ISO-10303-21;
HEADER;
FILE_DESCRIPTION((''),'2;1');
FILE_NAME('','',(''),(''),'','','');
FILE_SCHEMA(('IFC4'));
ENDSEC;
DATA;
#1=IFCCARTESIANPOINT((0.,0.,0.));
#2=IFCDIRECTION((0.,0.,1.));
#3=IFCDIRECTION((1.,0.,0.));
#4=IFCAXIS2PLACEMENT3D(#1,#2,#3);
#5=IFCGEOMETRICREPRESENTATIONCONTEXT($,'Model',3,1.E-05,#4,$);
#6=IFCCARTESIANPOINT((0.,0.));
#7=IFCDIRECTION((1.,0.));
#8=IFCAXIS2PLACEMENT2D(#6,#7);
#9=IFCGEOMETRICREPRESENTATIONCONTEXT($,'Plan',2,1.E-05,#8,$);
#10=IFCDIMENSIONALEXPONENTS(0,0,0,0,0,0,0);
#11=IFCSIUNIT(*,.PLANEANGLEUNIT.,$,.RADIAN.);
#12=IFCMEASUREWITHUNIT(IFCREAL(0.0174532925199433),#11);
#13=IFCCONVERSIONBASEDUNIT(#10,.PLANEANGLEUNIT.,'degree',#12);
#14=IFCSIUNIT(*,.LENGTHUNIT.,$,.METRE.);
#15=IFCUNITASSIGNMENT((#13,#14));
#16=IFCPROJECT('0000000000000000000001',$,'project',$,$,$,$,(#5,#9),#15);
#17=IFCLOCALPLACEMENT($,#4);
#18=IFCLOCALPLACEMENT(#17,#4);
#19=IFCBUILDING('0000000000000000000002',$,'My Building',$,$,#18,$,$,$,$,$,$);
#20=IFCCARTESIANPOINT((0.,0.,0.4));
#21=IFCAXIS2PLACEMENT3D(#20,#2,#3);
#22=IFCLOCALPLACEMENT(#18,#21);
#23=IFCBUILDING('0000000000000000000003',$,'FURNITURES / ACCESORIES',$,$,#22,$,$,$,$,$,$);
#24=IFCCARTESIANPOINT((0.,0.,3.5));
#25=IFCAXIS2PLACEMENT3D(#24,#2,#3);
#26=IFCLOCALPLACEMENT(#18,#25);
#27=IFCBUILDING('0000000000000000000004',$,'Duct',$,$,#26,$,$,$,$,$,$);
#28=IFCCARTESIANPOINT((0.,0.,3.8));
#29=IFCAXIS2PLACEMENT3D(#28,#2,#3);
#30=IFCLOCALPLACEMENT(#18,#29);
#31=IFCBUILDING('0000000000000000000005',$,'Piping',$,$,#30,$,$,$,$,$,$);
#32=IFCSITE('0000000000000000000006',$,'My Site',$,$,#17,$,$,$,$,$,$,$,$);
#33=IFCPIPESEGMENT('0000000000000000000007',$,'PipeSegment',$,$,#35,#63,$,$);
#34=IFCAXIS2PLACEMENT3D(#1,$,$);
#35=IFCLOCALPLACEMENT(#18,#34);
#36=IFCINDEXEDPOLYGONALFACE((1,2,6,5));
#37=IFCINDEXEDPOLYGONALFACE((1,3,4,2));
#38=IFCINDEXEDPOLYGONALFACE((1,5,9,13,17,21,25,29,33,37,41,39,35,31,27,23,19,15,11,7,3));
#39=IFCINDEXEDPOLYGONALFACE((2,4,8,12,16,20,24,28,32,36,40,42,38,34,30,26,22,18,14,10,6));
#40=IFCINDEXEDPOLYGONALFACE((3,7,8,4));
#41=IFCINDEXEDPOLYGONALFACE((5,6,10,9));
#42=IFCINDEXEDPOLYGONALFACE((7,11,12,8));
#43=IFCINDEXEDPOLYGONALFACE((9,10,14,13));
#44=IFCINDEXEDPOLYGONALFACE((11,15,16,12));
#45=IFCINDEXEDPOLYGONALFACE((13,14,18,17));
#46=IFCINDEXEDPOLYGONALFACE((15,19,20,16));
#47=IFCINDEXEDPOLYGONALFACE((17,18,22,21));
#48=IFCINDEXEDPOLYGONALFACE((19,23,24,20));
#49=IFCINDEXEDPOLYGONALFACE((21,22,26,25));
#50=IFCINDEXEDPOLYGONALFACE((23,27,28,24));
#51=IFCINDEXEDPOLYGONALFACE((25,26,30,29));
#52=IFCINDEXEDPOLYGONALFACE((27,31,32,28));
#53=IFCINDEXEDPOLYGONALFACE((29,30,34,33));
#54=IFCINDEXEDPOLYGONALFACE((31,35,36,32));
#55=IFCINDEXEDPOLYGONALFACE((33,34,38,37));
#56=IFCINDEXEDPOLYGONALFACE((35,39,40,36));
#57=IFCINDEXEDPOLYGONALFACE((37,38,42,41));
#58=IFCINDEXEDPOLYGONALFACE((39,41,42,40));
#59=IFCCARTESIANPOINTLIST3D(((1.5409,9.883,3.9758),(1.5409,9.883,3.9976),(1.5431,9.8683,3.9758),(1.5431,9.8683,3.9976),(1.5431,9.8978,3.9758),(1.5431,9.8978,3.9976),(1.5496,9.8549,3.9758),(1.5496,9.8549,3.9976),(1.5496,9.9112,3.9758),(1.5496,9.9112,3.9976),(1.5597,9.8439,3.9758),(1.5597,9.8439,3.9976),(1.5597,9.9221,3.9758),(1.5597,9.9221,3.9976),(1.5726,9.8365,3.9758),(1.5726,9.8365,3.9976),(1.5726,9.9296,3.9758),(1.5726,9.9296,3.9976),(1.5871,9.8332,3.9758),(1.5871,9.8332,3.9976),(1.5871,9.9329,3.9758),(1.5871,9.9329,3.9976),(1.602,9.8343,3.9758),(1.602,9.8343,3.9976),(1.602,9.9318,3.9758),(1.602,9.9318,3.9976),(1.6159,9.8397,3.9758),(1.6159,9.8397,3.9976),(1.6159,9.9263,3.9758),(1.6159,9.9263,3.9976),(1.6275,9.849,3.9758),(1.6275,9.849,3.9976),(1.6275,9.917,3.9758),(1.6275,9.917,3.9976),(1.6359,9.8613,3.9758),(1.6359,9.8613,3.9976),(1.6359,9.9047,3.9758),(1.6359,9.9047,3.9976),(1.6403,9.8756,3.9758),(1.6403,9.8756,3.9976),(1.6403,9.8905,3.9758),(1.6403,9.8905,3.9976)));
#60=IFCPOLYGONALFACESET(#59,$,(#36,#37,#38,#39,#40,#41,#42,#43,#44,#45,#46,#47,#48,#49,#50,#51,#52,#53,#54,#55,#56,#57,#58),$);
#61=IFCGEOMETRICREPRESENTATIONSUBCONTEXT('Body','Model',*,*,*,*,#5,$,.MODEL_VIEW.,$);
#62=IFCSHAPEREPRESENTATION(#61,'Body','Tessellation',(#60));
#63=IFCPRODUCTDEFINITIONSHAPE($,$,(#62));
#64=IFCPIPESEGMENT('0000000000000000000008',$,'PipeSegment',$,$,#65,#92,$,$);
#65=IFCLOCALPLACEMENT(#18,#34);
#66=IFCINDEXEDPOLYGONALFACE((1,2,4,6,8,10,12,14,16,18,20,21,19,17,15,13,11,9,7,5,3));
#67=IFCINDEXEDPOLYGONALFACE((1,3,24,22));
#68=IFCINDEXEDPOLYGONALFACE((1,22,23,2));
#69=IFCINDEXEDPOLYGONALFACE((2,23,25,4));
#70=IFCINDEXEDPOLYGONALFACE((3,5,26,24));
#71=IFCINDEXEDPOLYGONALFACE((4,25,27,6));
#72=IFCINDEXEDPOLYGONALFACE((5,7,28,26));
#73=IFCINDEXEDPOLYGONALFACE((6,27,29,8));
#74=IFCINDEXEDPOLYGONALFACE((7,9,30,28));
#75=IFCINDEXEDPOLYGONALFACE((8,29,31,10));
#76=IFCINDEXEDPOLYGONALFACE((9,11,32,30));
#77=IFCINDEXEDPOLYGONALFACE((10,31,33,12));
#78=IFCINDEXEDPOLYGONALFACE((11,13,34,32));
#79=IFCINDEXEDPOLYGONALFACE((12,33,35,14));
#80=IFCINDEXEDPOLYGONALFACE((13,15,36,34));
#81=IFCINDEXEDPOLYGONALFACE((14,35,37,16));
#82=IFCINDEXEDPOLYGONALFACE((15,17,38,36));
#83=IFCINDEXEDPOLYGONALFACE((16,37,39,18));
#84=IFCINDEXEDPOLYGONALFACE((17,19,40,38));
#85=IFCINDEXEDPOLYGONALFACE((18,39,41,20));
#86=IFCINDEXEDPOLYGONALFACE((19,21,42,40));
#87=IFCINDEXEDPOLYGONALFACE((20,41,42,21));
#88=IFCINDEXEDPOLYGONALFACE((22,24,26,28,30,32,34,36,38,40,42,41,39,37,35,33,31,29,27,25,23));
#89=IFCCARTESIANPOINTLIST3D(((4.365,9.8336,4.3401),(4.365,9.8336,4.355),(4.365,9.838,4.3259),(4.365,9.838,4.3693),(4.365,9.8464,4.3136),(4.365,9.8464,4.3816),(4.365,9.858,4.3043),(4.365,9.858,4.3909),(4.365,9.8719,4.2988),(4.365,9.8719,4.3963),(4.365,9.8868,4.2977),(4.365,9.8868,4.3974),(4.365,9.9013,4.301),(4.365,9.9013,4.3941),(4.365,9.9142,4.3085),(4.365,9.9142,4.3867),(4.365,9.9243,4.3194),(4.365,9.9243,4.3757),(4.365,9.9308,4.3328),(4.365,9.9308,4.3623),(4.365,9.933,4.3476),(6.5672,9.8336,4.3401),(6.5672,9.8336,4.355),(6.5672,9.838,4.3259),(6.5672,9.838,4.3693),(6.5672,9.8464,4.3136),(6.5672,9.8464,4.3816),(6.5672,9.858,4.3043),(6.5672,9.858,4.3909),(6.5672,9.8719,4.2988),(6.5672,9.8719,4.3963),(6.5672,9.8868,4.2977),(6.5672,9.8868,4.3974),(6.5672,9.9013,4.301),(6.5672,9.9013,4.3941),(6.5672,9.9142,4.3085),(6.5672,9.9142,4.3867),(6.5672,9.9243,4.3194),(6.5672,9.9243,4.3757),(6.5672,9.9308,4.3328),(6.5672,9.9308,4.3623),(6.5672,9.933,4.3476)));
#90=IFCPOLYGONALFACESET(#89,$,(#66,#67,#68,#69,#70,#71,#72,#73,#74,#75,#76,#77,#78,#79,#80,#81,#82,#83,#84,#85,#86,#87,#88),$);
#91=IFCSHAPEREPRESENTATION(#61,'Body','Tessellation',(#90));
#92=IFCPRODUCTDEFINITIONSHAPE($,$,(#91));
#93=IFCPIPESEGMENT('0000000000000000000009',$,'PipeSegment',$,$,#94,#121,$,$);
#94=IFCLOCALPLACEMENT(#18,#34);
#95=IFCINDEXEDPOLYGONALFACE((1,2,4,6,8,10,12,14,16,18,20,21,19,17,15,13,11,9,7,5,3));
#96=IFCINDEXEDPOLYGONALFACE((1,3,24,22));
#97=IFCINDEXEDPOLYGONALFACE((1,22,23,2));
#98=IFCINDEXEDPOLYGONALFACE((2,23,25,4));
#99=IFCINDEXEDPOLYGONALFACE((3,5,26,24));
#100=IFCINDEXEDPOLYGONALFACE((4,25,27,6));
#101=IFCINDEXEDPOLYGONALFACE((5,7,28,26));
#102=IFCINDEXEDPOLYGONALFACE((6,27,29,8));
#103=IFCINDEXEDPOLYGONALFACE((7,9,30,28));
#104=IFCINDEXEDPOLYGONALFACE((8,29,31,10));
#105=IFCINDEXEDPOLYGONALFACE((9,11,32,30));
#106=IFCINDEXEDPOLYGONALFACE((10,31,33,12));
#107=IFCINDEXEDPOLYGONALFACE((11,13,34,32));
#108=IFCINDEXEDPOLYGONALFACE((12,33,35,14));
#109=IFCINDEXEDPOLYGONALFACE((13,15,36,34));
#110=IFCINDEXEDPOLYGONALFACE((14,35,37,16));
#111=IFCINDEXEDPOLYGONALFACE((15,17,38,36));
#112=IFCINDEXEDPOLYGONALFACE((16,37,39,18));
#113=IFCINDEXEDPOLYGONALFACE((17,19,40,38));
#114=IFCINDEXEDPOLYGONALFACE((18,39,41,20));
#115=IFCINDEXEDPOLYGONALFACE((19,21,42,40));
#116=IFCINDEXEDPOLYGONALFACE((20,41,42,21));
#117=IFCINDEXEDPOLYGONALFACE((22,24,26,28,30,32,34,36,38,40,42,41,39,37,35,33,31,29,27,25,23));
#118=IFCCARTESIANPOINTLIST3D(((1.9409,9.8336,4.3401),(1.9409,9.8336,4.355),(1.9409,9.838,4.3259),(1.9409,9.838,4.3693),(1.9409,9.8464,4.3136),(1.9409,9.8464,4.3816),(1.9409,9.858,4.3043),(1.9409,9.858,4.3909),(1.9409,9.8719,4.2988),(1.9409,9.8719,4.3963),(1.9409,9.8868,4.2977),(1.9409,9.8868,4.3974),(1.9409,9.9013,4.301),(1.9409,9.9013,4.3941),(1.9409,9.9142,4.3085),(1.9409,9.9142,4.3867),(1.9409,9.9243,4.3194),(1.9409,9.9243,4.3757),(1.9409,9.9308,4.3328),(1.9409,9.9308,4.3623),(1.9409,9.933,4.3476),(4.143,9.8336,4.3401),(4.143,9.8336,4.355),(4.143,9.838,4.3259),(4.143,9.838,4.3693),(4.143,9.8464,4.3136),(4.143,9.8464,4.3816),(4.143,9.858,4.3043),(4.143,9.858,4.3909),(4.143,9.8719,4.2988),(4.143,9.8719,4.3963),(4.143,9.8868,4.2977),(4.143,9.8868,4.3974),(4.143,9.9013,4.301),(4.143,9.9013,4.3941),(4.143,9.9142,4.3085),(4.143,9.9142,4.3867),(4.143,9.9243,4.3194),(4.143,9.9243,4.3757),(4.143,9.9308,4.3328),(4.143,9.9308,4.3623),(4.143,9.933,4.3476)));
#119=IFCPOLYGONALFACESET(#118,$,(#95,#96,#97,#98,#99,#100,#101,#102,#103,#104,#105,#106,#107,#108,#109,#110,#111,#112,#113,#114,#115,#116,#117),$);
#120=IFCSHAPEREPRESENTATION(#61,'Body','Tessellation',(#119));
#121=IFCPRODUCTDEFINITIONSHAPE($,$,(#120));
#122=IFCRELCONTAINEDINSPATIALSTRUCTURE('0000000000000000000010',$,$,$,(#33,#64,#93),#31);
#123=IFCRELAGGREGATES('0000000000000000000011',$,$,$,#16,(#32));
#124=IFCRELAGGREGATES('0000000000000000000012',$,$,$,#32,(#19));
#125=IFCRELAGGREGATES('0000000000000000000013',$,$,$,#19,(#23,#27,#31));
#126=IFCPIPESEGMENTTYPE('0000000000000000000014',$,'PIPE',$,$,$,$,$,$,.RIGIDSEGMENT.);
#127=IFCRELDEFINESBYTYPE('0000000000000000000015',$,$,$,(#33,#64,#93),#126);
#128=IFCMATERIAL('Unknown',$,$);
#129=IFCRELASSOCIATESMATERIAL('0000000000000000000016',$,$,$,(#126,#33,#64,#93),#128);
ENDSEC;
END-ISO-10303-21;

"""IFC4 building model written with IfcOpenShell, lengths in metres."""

from ifc_helpers import new_model, entity, si_unit, converted_unit, frame, origin_with_axes, origin_2d_with_axis, place, context, subcontext, project, spatial, circle, extrude, material, material_profile, profile_set, profile_usage, type_object, element, save


model = new_model("IFC4")

# Units and contexts
model_context = context("Model", 3, precision=1e-05, world=origin_with_axes())
plan_context = context("Plan", 2, precision=1e-05, world=origin_2d_with_axis())
body_context = subcontext(model_context, "Body", "Model", "MODEL_VIEW")
ifc_project = project(units=[converted_unit("PLANEANGLEUNIT", "degree", entity("IfcReal", 0.0174532925199433), si_unit("PLANEANGLEUNIT", "RADIAN"), dimensions=[0, 0, 0, 0, 0, 0, 0]), si_unit("LENGTHUNIT", "METRE")], contexts=[model_context, plan_context])

# Site, building
site_placement = place(None, origin_with_axes())
site = spatial("IfcSite", under=ifc_project, at=site_placement, Name="My Site")
building_1_placement = place(site_placement, origin_with_axes())
building_1 = spatial("IfcBuilding", under=site, at=building_1_placement, Name="My Building")

# Shared definitions
ifc_material = material(Name="Unknown")

# Shared definitions
building_2_placement = place(building_1_placement, frame((0.0, 0.0, 0.4), z_axis=(0.0, 0.0, 1.0), x_axis=(1.0, 0.0, 0.0)))
building_2 = spatial("IfcBuilding", under=building_1, at=building_2_placement, Name="FURNITURES / ACCESORIES")

# Shared definitions
building_3_placement = place(building_1_placement, frame((0.0, 0.0, 3.5), z_axis=(0.0, 0.0, 1.0), x_axis=(1.0, 0.0, 0.0)))
building_3 = spatial("IfcBuilding", under=building_1, at=building_3_placement, Name="Duct")

# Shared definitions
building_4_placement = place(building_1_placement, frame((0.0, 0.0, 3.8), z_axis=(0.0, 0.0, 1.0), x_axis=(1.0, 0.0, 0.0)))
building_4 = spatial("IfcBuilding", under=building_1, at=building_4_placement, Name="Piping")

# Pipe segments
ifc_material_profile_1 = material_profile(ifc_material, circle(Radius=0.05))
ifc_profile_set_1 = profile_set([ifc_material_profile_1])
pipe_segment_type = type_object("IfcPipeSegmentType", Name="PIPE", PredefinedType="RIGIDSEGMENT", material=ifc_profile_set_1)
ifc_profile_usage_1 = profile_usage(ifc_profile_set_1, cardinal=5)
pipe_segment_1_placement = place(building_4_placement, frame((1.5909, 9.883, 0.1976), z_axis=(0.0, 0.0, -1.0), x_axis=(-1.0, 0.0, 0.0)))
element("IfcPipeSegment", 1, at=pipe_segment_1_placement, inside=building_4, type_object=pipe_segment_type, material=ifc_profile_usage_1, Name="PipeSegment", context=body_context, shape_type="SweptSolid", body=[
    extrude(circle(Radius=0.05), origin_with_axes(), (0.0, 0.0, 1.0), 0.0218),
])
ifc_profile_usage_2 = profile_usage(ifc_profile_set_1, cardinal=5)
pipe_segment_2_placement = place(building_4_placement, frame((4.365, 9.883, 0.5476), z_axis=(1.0, -0.000001, 0.000001), x_axis=(0.000001, 1.0, 0.0)))
element("IfcPipeSegment", 2, at=pipe_segment_2_placement, inside=building_4, type_object=pipe_segment_type, material=ifc_profile_usage_2, Name="PipeSegment", context=body_context, shape_type="SweptSolid", body=[
    extrude(circle(Radius=0.05), origin_with_axes(), (0.0, 0.0, 1.0), 2.2022),
])
ifc_profile_usage_3 = profile_usage(ifc_profile_set_1, cardinal=5)
pipe_segment_3_placement = place(building_4_placement, frame((4.143, 9.883, 0.5476), z_axis=(-1.0, -0.000001, -0.000001), x_axis=(-0.000001, 1.0, 0.0)))
element("IfcPipeSegment", 3, at=pipe_segment_3_placement, inside=building_4, type_object=pipe_segment_type, material=ifc_profile_usage_3, Name="PipeSegment", context=body_context, shape_type="SweptSolid", body=[
    extrude(circle(Radius=0.05), origin_with_axes(), (0.0, 0.0, 1.0), 2.2022),
])

save(model, "model.ifc")
